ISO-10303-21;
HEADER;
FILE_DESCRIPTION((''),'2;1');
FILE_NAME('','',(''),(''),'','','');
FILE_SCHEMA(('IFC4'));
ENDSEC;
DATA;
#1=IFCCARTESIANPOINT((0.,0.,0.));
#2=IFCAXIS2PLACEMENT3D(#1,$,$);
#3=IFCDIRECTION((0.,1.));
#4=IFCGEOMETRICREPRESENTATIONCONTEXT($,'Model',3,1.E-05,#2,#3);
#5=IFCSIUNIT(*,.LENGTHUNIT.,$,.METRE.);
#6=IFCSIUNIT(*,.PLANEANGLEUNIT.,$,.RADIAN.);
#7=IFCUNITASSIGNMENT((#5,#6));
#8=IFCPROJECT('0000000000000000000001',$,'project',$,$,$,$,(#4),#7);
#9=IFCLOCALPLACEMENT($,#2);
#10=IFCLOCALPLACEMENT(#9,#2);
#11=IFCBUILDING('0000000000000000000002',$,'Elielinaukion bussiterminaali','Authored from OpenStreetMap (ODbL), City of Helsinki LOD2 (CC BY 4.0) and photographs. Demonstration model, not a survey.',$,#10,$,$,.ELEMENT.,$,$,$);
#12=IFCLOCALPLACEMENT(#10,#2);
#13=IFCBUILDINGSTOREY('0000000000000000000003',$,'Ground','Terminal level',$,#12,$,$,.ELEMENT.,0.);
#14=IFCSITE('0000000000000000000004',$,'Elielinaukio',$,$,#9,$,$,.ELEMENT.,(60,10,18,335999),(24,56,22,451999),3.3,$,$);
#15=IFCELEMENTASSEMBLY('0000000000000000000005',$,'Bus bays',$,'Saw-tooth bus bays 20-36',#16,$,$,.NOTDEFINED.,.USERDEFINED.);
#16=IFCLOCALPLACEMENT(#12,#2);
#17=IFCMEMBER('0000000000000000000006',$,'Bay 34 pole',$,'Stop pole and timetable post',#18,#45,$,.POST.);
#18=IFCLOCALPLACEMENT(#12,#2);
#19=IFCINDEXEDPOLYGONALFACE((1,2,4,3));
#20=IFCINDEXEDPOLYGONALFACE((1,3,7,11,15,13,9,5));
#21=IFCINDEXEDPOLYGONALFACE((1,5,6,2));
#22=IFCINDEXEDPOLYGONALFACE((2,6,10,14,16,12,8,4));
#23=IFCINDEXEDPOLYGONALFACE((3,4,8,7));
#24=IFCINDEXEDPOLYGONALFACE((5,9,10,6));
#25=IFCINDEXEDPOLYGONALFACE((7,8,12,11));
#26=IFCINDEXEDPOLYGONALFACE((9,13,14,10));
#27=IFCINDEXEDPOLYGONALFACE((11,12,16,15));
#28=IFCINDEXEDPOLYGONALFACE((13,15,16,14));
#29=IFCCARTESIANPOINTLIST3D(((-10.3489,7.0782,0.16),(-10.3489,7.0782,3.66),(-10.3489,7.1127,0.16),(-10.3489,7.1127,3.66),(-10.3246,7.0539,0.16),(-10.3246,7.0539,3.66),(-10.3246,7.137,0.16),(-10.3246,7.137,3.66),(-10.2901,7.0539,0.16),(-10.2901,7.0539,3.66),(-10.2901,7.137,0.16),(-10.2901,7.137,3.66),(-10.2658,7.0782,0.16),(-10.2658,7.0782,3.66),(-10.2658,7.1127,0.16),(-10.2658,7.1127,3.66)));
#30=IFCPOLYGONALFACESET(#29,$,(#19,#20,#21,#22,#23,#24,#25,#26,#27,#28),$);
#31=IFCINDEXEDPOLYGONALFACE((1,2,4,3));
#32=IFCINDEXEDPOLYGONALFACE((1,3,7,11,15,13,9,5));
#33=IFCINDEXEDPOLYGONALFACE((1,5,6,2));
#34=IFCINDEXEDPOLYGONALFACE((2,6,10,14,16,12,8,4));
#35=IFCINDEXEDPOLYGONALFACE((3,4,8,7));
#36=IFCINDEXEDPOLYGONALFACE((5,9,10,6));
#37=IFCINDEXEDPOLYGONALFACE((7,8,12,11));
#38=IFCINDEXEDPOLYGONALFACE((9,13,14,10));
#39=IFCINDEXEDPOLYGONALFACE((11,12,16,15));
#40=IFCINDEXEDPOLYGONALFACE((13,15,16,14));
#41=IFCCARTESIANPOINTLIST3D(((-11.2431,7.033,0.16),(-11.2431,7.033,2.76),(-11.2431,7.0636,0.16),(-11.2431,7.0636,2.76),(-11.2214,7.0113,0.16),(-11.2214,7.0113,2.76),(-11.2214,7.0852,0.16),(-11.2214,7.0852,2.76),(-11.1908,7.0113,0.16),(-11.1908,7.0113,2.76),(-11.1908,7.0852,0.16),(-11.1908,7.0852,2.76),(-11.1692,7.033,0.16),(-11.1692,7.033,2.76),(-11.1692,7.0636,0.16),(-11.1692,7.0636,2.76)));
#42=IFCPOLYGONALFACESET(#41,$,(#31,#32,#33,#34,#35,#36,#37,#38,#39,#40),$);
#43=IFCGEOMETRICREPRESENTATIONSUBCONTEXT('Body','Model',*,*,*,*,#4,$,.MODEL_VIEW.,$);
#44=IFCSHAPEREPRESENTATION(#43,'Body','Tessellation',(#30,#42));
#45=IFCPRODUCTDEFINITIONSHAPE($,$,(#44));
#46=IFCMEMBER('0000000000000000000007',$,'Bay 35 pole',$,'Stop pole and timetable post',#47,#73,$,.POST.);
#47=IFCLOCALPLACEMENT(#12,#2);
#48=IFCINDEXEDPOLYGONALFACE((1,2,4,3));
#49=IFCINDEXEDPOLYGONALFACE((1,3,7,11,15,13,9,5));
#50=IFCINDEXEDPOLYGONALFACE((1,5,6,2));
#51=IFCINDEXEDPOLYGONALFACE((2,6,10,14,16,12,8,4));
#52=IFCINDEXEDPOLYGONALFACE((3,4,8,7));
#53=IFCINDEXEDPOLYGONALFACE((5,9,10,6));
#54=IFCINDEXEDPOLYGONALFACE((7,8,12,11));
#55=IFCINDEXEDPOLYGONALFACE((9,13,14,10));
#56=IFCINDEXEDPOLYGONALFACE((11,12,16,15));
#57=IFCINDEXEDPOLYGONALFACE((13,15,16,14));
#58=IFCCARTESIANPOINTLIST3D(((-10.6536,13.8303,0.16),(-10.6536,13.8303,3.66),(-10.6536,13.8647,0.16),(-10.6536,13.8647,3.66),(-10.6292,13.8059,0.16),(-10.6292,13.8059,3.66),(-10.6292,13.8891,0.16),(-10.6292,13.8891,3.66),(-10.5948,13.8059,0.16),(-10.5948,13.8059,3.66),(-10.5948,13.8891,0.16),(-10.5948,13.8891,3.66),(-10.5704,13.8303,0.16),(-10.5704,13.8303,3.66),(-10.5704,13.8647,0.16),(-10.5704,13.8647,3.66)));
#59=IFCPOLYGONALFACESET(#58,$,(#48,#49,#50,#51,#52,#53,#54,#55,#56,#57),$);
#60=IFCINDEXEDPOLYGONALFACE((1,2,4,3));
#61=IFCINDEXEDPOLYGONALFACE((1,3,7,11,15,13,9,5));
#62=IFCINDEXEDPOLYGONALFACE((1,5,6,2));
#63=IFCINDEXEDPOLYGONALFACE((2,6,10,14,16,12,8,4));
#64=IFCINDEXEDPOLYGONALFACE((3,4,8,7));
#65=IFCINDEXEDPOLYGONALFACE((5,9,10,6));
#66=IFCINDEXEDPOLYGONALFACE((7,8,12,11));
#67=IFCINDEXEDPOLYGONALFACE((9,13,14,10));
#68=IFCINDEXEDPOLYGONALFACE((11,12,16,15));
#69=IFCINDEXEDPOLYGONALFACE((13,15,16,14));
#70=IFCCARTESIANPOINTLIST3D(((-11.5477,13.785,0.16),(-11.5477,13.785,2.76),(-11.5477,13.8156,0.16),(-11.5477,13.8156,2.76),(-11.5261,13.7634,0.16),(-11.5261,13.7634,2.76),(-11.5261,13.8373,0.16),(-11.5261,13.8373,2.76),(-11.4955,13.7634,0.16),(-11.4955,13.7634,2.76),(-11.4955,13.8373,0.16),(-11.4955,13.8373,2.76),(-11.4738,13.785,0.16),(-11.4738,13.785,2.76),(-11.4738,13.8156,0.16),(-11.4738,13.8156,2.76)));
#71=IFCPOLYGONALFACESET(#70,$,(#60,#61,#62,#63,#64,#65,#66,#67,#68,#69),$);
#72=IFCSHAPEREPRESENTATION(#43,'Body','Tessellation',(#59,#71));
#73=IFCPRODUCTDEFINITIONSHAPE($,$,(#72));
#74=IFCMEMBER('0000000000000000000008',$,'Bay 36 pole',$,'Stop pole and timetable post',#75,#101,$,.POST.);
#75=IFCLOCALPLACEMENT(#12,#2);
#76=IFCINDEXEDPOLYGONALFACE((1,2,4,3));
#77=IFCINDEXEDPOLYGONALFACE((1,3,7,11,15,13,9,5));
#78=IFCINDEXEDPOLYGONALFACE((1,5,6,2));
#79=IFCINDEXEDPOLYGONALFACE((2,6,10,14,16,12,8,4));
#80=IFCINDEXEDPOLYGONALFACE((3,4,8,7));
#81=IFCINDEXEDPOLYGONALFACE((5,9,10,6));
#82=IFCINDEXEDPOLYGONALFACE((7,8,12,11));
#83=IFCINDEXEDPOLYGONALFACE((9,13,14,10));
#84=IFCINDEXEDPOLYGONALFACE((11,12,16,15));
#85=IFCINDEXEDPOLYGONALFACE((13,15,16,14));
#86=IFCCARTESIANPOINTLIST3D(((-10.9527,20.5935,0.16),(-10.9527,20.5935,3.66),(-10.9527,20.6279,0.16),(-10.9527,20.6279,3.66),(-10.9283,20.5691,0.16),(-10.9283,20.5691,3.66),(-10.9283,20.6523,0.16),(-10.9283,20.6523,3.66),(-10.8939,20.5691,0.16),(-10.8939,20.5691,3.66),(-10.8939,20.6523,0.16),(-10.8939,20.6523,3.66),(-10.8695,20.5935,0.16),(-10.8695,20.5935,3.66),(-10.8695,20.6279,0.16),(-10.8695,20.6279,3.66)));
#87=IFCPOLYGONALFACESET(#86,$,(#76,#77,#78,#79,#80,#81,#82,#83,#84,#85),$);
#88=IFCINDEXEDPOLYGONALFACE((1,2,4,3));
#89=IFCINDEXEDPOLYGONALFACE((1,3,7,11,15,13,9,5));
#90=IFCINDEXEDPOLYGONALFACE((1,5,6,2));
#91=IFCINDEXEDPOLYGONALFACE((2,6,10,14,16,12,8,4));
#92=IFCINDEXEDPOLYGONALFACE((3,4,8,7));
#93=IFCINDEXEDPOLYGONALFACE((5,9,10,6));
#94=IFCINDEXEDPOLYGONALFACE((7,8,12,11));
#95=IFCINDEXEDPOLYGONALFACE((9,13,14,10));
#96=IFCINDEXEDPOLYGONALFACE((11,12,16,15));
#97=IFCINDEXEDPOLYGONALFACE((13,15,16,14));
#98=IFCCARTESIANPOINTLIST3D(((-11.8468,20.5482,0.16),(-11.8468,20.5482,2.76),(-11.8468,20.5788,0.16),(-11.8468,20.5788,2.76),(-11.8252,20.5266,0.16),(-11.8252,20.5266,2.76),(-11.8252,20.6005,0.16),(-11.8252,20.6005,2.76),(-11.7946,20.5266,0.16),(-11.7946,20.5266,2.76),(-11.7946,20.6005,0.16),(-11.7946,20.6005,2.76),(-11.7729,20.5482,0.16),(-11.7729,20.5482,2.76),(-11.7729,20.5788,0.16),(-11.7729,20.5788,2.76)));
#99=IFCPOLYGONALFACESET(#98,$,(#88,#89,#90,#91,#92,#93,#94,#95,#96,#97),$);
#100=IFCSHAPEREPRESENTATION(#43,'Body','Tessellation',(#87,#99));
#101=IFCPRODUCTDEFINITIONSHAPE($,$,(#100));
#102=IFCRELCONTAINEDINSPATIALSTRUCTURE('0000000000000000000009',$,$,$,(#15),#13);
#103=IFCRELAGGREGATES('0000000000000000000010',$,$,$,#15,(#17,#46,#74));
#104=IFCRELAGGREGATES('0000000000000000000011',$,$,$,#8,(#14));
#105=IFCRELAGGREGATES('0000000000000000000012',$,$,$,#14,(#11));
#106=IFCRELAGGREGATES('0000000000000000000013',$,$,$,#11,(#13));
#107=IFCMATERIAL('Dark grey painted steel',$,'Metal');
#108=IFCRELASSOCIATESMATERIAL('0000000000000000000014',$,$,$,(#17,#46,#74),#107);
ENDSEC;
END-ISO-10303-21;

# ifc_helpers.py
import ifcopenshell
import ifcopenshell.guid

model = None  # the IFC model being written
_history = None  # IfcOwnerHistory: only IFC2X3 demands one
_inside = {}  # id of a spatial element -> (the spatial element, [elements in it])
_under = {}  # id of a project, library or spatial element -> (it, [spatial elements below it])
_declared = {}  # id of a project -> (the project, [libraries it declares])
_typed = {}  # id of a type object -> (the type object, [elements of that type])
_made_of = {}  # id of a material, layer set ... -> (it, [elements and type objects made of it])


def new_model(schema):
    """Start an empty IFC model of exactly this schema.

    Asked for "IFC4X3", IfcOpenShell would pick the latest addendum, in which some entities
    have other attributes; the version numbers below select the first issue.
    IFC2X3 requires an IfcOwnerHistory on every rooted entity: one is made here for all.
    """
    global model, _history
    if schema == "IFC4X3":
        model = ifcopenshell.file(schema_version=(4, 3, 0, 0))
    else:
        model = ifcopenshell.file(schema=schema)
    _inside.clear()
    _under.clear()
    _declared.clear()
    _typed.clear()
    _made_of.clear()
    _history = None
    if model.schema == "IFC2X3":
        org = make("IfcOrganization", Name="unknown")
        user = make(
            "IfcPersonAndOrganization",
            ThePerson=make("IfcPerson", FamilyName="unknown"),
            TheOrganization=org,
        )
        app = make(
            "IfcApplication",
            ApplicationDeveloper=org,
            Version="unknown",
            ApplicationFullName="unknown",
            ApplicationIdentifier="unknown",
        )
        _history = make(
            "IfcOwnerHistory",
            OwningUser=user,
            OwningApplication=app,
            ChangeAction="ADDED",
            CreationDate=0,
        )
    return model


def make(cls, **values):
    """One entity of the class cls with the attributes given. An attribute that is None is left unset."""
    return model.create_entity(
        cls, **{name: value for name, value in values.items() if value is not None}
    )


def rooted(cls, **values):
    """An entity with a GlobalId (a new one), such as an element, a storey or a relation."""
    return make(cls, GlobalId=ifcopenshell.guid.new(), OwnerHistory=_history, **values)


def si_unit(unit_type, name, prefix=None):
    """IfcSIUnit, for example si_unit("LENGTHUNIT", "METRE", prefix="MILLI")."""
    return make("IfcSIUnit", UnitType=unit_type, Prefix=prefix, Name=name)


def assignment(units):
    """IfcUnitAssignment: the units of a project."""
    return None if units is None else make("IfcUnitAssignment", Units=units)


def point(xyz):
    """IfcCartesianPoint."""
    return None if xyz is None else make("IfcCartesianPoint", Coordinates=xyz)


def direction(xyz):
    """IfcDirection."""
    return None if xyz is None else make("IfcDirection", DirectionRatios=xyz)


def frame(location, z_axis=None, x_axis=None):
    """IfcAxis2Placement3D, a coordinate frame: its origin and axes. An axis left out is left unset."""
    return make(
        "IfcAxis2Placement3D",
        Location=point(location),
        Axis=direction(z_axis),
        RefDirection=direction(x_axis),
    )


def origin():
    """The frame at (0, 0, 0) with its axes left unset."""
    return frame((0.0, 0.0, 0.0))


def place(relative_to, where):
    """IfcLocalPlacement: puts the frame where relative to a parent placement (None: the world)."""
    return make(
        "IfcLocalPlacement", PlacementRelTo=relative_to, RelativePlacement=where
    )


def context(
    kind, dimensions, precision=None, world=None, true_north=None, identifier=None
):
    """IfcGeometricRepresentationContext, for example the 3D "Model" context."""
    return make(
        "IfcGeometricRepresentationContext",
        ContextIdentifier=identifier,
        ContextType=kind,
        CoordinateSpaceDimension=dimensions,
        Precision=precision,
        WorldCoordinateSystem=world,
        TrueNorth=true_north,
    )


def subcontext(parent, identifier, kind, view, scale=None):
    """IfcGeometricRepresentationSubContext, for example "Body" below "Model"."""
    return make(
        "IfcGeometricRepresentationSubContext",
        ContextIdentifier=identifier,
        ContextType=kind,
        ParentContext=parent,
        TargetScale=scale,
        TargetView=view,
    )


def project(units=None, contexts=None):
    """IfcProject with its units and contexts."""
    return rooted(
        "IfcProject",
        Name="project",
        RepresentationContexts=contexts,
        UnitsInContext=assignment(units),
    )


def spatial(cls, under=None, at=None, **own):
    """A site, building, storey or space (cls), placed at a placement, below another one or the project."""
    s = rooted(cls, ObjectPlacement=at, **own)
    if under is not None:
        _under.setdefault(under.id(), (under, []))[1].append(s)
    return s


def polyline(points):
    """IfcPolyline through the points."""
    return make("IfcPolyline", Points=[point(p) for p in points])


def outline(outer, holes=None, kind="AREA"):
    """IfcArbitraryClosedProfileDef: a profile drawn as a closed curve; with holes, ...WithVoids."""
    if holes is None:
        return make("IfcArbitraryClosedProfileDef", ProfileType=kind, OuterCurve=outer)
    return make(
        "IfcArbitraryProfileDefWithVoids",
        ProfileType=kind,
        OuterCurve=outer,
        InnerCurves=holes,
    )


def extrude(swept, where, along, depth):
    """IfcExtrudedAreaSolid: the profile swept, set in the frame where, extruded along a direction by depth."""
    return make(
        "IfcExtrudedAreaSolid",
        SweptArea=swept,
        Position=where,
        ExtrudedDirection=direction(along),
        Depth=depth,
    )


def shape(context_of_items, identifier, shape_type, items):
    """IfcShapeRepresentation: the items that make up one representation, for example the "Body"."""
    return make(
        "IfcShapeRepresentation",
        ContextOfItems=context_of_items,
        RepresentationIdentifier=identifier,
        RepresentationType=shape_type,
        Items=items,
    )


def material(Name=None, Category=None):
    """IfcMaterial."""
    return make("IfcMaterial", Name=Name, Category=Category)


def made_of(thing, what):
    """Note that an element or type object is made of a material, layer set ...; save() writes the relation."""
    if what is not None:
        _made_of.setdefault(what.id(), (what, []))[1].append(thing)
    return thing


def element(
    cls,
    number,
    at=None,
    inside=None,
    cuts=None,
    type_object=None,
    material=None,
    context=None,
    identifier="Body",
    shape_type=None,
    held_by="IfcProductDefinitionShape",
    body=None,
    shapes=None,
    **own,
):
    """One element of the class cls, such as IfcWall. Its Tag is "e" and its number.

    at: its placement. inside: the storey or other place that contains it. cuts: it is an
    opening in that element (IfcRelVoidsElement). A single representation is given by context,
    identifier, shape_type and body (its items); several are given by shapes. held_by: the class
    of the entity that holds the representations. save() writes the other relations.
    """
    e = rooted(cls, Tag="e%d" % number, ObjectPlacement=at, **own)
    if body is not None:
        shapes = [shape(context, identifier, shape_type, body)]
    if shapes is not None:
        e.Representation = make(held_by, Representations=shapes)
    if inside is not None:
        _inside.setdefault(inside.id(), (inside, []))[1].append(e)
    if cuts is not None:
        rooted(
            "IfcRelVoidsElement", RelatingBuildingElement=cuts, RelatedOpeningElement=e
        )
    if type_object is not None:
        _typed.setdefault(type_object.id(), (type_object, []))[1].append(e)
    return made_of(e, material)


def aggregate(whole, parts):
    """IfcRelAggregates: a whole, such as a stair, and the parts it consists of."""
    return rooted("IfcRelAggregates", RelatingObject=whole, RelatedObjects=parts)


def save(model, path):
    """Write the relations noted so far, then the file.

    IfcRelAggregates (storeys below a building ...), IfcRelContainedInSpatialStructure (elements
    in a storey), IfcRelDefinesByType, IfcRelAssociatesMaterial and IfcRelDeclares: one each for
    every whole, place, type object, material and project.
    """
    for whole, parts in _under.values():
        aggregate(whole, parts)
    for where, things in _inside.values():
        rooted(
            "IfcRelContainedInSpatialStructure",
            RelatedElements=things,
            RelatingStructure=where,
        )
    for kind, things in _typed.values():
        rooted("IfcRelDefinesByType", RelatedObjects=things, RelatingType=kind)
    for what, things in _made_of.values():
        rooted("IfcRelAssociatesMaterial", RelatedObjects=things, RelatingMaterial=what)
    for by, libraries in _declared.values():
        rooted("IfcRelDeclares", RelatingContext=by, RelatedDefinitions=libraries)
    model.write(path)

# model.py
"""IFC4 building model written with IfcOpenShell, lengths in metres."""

from ifc_helpers import new_model, si_unit, direction, frame, origin, place, context, subcontext, project, spatial, polyline, outline, extrude, material, element, aggregate, save


model = new_model("IFC4")

# Units and contexts
model_context = context("Model", 3, precision=1e-05, world=origin(), true_north=direction((0.0, 1.0)))
body_context = subcontext(model_context, "Body", "Model", "MODEL_VIEW")
ifc_project = project(units=[si_unit("LENGTHUNIT", "METRE"), si_unit("PLANEANGLEUNIT", "RADIAN")], contexts=[model_context])

# Site, building, storey
site_placement = place(None, origin())
site = spatial("IfcSite", under=ifc_project, at=site_placement, Name="Elielinaukio", CompositionType="ELEMENT", RefLatitude=(60, 10, 18, 335999), RefLongitude=(24, 56, 22, 451999), RefElevation=3.3)
building_placement = place(site_placement, origin())
building = spatial("IfcBuilding", under=site, at=building_placement, Name="Elielinaukion bussiterminaali", Description="Authored from OpenStreetMap (ODbL), City of Helsinki LOD2 (CC BY 4.0) and photographs. Demonstration model, not a survey.", CompositionType="ELEMENT")
storey_placement = place(building_placement, origin())
storey = spatial("IfcBuildingStorey", under=building, at=storey_placement, Name="Ground", Description="Terminal level", CompositionType="ELEMENT", Elevation=0.0)

# Element assembly, members
assembly_1_placement = place(building_placement, origin())
assembly_1 = element("IfcElementAssembly", 1, at=assembly_1_placement, inside=storey, Name="Bus bays", ObjectType="Saw-tooth bus bays 20-36", AssemblyPlace="NOTDEFINED", PredefinedType="USERDEFINED")
ifc_material_1 = material(Name="Dark grey painted steel", Category="Metal")
member_1_placement = place(building_placement, origin())
member_1 = element("IfcMember", 2, at=member_1_placement, material=ifc_material_1, Name="Bay 34 pole", ObjectType="Stop pole and timetable post", PredefinedType="POST", context=body_context, shape_type="SweptSolid", body=[
    extrude(outline(polyline([(-10.2658, 7.1127), (-10.2901, 7.137), (-10.3246, 7.137), (-10.3489, 7.1127), (-10.3489, 7.0782), (-10.3246, 7.0539), (-10.2901, 7.0539), (-10.2658, 7.0782), (-10.2658, 7.1127)])), frame((0.0, 0.0, 0.16)), (0.0, 0.0, 1.0), 3.5),
    extrude(outline(polyline([(-11.1692, 7.0636), (-11.1908, 7.0852), (-11.2214, 7.0852), (-11.2431, 7.0636), (-11.2431, 7.033), (-11.2214, 7.0113), (-11.1908, 7.0113), (-11.1692, 7.033), (-11.1692, 7.0636)])), frame((0.0, 0.0, 0.16)), (0.0, 0.0, 1.0), 2.6),
])
member_2_placement = place(building_placement, origin())
member_2 = element("IfcMember", 3, at=member_2_placement, material=ifc_material_1, Name="Bay 35 pole", ObjectType="Stop pole and timetable post", PredefinedType="POST", context=body_context, shape_type="SweptSolid", body=[
    extrude(outline(polyline([(-10.5704, 13.8647), (-10.5948, 13.8891), (-10.6292, 13.8891), (-10.6536, 13.8647), (-10.6536, 13.8303), (-10.6292, 13.8059), (-10.5948, 13.8059), (-10.5704, 13.8303), (-10.5704, 13.8647)])), frame((0.0, 0.0, 0.16)), (0.0, 0.0, 1.0), 3.5),
    extrude(outline(polyline([(-11.4738, 13.8156), (-11.4955, 13.8373), (-11.5261, 13.8373), (-11.5477, 13.8156), (-11.5477, 13.785), (-11.5261, 13.7634), (-11.4955, 13.7634), (-11.4738, 13.785), (-11.4738, 13.8156)])), frame((0.0, 0.0, 0.16)), (0.0, 0.0, 1.0), 2.6),
])
member_3_placement = place(building_placement, origin())
member_3 = element("IfcMember", 4, at=member_3_placement, material=ifc_material_1, Name="Bay 36 pole", ObjectType="Stop pole and timetable post", PredefinedType="POST", context=body_context, shape_type="SweptSolid", body=[
    extrude(outline(polyline([(-10.8695, 20.6279), (-10.8939, 20.6523), (-10.9283, 20.6523), (-10.9527, 20.6279), (-10.9527, 20.5935), (-10.9283, 20.5691), (-10.8939, 20.5691), (-10.8695, 20.5935), (-10.8695, 20.6279)])), frame((0.0, 0.0, 0.16)), (0.0, 0.0, 1.0), 3.5),
    extrude(outline(polyline([(-11.7729, 20.5788), (-11.7946, 20.6005), (-11.8252, 20.6005), (-11.8468, 20.5788), (-11.8468, 20.5482), (-11.8252, 20.5266), (-11.7946, 20.5266), (-11.7729, 20.5482), (-11.7729, 20.5788)])), frame((0.0, 0.0, 0.16)), (0.0, 0.0, 1.0), 2.6),
])

aggregate(assembly_1, [member_1, member_2, member_3])

save(model, "model.ifc")
